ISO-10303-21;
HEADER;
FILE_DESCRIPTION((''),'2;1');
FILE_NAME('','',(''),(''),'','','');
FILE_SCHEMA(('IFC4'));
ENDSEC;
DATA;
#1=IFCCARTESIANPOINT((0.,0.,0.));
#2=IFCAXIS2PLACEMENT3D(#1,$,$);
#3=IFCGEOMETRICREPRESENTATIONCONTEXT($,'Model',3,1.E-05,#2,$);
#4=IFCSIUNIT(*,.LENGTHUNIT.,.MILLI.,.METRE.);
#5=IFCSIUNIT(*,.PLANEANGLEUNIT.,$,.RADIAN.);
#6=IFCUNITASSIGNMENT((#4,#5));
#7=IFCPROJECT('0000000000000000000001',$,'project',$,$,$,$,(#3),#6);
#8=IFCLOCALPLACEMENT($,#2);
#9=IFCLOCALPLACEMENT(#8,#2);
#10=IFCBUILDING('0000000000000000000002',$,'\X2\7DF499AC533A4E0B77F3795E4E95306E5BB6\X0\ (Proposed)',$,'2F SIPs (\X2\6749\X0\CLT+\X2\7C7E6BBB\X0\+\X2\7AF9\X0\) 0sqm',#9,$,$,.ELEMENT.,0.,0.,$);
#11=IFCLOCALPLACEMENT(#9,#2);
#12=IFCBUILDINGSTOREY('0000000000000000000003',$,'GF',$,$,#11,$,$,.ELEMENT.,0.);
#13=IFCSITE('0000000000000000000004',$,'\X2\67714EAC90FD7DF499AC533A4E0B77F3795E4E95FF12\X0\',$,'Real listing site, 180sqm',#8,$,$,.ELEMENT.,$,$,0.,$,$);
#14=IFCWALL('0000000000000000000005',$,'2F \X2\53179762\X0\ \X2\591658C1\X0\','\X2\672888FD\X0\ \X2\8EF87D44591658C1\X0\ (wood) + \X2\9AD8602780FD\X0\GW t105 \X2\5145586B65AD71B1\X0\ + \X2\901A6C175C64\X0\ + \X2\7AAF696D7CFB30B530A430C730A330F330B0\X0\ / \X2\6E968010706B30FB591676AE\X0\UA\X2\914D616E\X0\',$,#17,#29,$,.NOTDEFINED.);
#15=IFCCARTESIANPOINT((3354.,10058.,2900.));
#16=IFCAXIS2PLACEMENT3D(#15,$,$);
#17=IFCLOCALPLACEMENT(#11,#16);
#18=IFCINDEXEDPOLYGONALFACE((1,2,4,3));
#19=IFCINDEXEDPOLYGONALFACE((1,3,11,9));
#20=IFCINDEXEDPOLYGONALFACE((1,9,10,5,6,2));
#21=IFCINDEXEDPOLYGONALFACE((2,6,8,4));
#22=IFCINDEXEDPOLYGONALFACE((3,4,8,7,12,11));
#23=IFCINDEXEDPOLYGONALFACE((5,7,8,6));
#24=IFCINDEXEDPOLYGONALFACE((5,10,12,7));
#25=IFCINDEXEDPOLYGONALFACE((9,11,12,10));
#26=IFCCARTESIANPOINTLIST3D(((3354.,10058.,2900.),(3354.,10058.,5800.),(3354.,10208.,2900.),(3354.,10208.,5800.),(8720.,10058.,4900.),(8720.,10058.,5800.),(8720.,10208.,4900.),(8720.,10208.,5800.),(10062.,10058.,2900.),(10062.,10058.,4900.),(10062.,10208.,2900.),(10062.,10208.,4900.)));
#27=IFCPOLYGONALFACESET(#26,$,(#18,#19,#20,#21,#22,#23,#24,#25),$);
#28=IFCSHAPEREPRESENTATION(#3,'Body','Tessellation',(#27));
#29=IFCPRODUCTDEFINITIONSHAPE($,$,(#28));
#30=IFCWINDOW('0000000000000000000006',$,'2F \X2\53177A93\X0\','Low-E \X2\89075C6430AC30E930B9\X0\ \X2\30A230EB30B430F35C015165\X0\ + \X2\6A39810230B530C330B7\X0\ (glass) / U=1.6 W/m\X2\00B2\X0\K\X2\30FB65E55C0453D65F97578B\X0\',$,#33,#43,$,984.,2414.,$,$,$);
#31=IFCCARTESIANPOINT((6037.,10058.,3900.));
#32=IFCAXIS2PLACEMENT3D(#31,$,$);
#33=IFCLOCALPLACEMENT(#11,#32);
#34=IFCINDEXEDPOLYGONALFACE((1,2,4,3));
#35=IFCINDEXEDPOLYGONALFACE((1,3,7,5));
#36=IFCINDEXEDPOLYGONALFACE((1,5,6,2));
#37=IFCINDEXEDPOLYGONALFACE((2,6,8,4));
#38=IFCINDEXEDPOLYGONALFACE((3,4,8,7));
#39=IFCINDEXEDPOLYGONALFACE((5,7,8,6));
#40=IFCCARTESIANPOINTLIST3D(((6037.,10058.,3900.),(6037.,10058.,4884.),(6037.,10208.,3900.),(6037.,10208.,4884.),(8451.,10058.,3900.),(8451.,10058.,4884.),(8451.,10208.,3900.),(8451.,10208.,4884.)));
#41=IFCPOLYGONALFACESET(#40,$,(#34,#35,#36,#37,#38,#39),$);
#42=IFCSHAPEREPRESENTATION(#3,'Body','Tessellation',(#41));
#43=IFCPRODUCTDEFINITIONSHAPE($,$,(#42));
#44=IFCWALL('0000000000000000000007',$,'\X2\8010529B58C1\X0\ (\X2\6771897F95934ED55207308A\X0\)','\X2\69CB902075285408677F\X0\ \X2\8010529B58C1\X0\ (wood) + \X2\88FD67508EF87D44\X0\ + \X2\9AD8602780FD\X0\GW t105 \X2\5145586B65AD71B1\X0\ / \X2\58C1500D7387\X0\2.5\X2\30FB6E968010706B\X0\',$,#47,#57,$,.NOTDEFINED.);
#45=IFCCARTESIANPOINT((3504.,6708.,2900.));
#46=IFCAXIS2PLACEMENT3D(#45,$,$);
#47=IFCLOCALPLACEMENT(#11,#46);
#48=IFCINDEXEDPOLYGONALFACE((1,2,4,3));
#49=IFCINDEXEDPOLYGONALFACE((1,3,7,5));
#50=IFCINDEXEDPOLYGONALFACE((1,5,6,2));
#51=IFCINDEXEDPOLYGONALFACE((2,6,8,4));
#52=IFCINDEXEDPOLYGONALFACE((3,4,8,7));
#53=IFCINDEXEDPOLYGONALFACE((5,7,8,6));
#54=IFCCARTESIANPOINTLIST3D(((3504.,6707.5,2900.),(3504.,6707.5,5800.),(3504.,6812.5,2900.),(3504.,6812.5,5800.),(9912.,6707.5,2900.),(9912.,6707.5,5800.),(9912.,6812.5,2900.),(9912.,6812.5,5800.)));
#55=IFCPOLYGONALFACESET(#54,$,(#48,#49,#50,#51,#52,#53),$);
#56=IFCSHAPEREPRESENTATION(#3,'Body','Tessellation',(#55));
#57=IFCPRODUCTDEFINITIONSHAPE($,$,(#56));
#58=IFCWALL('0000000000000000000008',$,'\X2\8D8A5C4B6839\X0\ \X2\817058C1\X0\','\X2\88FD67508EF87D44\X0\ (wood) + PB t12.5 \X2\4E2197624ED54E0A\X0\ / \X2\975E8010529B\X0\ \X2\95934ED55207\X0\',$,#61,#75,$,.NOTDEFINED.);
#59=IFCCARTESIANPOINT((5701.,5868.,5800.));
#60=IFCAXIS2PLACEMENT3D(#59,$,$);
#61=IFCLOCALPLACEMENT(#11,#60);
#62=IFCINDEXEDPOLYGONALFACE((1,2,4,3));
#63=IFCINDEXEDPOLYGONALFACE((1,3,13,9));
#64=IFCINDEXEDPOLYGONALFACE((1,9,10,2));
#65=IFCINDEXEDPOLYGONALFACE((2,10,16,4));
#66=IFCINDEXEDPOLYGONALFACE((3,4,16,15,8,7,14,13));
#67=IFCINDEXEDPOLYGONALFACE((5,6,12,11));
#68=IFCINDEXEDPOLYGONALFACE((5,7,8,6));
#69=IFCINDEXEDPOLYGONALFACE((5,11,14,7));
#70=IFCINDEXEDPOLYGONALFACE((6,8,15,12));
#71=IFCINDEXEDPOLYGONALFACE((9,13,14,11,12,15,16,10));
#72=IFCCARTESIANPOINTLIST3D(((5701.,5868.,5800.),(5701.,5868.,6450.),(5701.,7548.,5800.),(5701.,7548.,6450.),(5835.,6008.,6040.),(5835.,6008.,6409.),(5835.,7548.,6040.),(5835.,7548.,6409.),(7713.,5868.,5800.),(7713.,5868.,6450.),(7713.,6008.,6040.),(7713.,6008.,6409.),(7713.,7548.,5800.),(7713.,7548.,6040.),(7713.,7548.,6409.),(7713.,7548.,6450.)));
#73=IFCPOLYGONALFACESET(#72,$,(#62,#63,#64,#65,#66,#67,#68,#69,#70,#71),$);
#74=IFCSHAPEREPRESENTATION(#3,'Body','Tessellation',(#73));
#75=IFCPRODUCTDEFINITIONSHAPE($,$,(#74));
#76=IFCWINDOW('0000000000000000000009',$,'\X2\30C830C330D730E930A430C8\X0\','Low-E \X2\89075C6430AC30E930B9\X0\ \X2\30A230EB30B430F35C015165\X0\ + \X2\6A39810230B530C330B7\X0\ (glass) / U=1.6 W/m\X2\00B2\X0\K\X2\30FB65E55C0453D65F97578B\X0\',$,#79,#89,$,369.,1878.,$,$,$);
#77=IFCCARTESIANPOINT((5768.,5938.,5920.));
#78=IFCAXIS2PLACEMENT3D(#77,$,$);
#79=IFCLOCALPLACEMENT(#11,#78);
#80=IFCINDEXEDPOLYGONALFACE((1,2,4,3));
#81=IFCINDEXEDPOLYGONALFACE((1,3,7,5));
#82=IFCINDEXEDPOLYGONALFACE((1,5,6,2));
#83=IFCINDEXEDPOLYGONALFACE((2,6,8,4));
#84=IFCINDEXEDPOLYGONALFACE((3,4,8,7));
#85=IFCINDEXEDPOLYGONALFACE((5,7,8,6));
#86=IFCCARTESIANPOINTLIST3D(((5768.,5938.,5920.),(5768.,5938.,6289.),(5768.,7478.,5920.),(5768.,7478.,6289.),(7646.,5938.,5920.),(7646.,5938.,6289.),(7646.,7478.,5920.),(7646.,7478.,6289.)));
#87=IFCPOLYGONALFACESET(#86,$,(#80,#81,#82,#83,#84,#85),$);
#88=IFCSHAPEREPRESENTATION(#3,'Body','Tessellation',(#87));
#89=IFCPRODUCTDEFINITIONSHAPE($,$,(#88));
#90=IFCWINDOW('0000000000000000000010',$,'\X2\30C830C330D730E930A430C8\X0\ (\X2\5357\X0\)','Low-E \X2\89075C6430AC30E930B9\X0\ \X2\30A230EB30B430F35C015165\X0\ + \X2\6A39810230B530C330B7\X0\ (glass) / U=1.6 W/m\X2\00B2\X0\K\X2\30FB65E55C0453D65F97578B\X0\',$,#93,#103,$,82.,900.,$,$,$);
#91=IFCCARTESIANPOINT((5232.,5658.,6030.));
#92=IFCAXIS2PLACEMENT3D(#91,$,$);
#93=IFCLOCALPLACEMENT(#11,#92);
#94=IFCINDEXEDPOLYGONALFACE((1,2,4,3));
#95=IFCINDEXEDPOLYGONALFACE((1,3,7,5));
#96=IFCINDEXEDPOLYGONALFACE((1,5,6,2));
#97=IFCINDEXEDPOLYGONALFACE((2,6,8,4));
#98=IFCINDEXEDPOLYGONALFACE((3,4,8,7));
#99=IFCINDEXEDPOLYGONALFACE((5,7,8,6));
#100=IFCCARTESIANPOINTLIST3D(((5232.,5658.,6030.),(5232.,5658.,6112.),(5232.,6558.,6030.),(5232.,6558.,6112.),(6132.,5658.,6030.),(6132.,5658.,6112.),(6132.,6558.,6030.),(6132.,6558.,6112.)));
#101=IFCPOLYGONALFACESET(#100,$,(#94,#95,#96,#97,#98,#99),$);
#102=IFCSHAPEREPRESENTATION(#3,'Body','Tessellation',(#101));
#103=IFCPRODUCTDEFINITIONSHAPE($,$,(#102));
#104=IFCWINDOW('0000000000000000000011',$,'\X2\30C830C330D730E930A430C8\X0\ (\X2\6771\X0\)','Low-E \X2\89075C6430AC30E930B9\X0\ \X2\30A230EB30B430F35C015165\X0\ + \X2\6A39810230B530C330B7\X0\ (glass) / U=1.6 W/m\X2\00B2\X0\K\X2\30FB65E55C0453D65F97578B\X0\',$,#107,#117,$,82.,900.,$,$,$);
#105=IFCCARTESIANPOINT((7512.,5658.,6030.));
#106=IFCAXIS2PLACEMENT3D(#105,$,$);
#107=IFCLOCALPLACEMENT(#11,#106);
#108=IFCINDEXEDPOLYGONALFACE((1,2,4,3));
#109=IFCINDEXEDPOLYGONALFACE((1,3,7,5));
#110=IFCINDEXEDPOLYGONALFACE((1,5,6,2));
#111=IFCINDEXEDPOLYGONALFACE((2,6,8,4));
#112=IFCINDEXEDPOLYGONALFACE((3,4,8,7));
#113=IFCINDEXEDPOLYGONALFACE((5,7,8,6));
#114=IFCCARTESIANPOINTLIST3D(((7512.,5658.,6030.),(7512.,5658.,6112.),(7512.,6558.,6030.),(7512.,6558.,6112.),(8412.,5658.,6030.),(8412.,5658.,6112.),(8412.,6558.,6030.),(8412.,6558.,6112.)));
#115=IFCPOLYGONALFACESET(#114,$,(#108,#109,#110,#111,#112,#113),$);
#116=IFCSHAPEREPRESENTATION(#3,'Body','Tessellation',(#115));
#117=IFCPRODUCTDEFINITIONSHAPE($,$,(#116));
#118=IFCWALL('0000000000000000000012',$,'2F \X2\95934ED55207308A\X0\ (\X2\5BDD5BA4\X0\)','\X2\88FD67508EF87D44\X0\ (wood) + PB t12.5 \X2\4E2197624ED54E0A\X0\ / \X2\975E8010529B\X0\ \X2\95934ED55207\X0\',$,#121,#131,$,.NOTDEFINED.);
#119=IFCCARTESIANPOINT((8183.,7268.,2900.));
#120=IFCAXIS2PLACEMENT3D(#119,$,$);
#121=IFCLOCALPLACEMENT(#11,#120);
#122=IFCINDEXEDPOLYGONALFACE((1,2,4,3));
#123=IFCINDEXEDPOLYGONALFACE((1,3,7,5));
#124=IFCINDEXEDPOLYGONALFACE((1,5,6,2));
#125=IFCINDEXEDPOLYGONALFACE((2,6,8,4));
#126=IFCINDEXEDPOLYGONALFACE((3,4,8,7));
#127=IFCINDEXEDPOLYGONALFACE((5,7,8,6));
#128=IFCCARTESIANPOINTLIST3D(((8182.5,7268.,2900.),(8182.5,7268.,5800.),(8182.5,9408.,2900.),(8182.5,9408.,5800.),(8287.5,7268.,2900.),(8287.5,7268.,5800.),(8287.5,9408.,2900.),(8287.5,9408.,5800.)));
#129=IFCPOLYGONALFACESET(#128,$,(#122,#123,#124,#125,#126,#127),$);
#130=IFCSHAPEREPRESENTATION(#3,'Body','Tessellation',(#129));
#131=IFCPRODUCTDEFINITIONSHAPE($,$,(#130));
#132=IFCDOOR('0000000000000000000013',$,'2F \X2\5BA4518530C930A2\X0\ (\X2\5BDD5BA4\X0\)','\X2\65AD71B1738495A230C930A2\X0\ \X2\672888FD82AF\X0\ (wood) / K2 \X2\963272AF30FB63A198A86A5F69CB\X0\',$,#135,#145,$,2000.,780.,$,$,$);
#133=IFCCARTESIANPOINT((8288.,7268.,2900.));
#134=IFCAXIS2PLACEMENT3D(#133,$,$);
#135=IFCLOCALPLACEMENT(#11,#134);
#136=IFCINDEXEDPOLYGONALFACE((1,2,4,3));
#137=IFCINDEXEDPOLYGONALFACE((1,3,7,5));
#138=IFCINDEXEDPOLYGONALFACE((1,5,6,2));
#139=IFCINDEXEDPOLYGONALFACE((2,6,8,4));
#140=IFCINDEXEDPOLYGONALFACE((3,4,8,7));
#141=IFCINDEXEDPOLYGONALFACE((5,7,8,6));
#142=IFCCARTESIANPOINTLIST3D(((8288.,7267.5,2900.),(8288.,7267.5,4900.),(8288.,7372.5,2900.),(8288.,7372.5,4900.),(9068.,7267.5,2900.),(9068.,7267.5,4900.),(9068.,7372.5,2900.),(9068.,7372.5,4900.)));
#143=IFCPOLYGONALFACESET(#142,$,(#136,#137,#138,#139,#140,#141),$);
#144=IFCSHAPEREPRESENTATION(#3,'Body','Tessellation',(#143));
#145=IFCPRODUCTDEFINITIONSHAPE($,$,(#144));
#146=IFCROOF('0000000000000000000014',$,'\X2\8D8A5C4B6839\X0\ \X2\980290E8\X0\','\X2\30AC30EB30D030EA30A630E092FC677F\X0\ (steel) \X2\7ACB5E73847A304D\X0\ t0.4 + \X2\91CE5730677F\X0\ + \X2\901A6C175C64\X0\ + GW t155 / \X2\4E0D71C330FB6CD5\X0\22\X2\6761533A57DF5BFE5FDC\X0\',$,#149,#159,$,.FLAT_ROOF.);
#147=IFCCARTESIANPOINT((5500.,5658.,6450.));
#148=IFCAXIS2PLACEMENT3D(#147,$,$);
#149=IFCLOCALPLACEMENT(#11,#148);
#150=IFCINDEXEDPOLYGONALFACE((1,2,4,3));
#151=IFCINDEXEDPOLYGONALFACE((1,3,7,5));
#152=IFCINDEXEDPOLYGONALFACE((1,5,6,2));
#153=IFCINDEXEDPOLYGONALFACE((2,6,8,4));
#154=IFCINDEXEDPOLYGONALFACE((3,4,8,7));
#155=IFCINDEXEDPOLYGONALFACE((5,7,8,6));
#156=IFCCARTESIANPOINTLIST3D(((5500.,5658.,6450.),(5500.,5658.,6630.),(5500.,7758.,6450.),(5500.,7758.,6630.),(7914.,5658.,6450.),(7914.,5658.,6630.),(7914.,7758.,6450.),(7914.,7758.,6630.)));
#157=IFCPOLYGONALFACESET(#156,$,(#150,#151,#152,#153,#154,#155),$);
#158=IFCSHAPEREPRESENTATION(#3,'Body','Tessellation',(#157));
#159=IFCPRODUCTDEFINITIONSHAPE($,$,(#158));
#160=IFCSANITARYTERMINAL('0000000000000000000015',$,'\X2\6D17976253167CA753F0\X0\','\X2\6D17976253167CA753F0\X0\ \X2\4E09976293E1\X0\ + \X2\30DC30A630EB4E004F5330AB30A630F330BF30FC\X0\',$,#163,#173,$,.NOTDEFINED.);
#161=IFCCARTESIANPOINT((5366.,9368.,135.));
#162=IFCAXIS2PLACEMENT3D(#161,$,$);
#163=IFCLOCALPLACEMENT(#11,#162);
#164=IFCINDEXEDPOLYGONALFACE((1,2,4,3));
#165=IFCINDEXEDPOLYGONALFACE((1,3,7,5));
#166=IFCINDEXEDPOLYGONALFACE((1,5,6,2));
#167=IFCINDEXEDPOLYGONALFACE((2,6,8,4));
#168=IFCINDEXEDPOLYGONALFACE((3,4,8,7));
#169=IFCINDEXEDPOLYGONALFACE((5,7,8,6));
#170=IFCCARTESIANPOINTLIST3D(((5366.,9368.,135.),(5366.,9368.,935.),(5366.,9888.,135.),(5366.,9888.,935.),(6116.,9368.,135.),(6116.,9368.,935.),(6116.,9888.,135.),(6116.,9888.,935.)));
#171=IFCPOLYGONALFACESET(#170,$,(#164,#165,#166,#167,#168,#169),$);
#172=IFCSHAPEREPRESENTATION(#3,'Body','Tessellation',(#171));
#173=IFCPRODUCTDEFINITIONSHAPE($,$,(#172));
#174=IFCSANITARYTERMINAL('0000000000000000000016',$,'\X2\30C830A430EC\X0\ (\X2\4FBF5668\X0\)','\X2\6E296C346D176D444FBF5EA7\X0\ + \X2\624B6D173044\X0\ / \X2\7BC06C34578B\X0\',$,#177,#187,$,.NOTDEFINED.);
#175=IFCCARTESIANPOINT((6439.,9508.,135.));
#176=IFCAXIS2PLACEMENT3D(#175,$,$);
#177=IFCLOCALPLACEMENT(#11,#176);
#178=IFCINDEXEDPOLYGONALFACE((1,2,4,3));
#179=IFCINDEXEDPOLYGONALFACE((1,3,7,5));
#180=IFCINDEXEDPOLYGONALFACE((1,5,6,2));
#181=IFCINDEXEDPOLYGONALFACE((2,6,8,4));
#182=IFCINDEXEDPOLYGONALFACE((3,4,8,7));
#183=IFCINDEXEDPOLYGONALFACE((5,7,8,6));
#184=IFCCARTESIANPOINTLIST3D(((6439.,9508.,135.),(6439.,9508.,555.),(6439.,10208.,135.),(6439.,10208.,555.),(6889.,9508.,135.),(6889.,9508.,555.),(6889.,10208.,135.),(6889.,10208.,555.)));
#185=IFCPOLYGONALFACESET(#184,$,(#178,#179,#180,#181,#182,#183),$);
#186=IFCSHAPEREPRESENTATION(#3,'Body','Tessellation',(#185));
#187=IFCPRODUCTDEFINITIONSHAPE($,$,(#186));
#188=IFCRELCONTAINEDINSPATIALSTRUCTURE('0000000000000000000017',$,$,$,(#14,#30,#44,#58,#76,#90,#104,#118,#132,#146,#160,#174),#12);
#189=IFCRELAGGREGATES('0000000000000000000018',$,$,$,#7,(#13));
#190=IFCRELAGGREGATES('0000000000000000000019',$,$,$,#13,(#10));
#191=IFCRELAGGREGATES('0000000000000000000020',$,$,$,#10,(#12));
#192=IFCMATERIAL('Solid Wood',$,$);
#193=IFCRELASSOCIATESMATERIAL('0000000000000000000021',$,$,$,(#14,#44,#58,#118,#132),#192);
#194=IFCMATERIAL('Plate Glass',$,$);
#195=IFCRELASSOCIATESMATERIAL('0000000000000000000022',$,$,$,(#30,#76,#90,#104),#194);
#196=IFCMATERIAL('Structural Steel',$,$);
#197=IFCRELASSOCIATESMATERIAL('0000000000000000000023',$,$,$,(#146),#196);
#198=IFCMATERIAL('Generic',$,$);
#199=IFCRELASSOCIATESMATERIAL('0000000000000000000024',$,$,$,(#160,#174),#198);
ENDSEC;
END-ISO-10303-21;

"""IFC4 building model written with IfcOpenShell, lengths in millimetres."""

from ifc_helpers import new_model, si_unit, frame, frame_2d, origin, place, context, project, spatial, rectangle, extrude, material, element, fill, save


model = new_model("IFC4")

# Units and contexts
model_context = context("Model", 3, precision=1e-05, world=origin())
ifc_project = project(units=[si_unit("LENGTHUNIT", "METRE", prefix="MILLI"), si_unit("PLANEANGLEUNIT", "RADIAN")], contexts=[model_context])

# Site, building, storey
site_placement = place(None, origin())
site = spatial("IfcSite", under=ifc_project, at=site_placement, Name="東京都練馬区下石神井２", ObjectType="Real listing site, 180sqm", CompositionType="ELEMENT", RefElevation=0.0)
building_placement = place(site_placement, origin())
building = spatial("IfcBuilding", under=site, at=building_placement, Name="練馬区下石神井の家 (Proposed)", ObjectType="2F SIPs (杉CLT+籾殻+竹) 0sqm", CompositionType="ELEMENT", ElevationOfRefHeight=0.0, ElevationOfTerrain=0.0)
storey_placement = place(building_placement, origin())
storey = spatial("IfcBuildingStorey", under=building, at=storey_placement, Name="GF", CompositionType="ELEMENT", Elevation=0.0)

# Wall, opening, window
ifc_material_1 = material(Name="Solid Wood")
wall_1_placement = place(storey_placement, frame((3354.0, 10058.0, 2900.0)))
wall_1 = element("IfcWall", 1, at=wall_1_placement, inside=storey, material=ifc_material_1, Name="2F 北面 外壁", Description="木製 軸組外壁 (wood) + 高性能GW t105 充填断熱 + 通気層 + 窯業系サイディング / 準耐火・外皮UA配慮", PredefinedType="NOTDEFINED", context=model_context, shape_type="SweptSolid", body=[
    extrude(rectangle(XDim=6708.0, YDim=150.0, at=frame_2d((3354.0, 75.0))), frame((3354.0, 10058.0, 2900.0)), (0.0, 0.0, 1.0), 2900.0),
])
opening_1_placement = place(storey_placement, frame((6037.0, 10058.0, 3900.0)))
opening_1 = element("IfcOpeningElement", 2, at=opening_1_placement, cuts=wall_1, PredefinedType="NOTDEFINED", context=model_context, shape_type="SweptSolid", body=[
    extrude(rectangle(XDim=2414.0, YDim=150.0, at=frame_2d((1207.0, 75.0))), frame((6037.0, 10058.0, 3900.0)), (0.0, 0.0, 1.0), 984.0),
])
ifc_material_2 = material(Name="Plate Glass")
window_1_placement = place(storey_placement, frame((6037.0, 10058.0, 3900.0)))
window_1 = element("IfcWindow", 3, at=window_1_placement, inside=storey, material=ifc_material_2, Name="2F 北窓", Description="Low-E 複層ガラス アルゴン封入 + 樹脂サッシ (glass) / U=1.6 W/m²K・日射取得型", OverallHeight=984.0, OverallWidth=2414.0, context=model_context, shape_type="SweptSolid", body=[
    extrude(rectangle(XDim=2414.0, YDim=150.0, at=frame_2d((1207.0, 75.0))), frame((6037.0, 10058.0, 3900.0)), (0.0, 0.0, 1.0), 984.0),
])
fill(opening_1, window_1)

# Wall
wall_2_placement = place(storey_placement, frame((3504.0, 6708.0, 2900.0)))
element("IfcWall", 4, at=wall_2_placement, inside=storey, material=ifc_material_1, Name="耐力壁 (東西間仕切り)", Description="構造用合板 耐力壁 (wood) + 製材軸組 + 高性能GW t105 充填断熱 / 壁倍率2.5・準耐火", PredefinedType="NOTDEFINED", context=model_context, shape_type="SweptSolid", body=[
    extrude(rectangle(XDim=6408.0, YDim=105.0, at=frame_2d((3204.0, 52.0))), frame((3504.0, 6708.0, 2900.0)), (0.0, 0.0, 1.0), 2900.0),
])

# Wall, openings, windows
wall_3_placement = place(storey_placement, frame((5701.0, 5868.0, 5800.0)))
wall_3 = element("IfcWall", 5, at=wall_3_placement, inside=storey, material=ifc_material_1, Name="越屋根 腰壁", Description="製材軸組 (wood) + PB t12.5 両面仕上 / 非耐力 間仕切", PredefinedType="NOTDEFINED", context=model_context, shape_type="SweptSolid", body=[
    extrude(rectangle(XDim=2012.0, YDim=1680.0, at=frame_2d((1006.0, 840.0))), frame((5701.0, 5868.0, 5800.0)), (0.0, 0.0, 1.0), 650.0),
])
opening_2_placement = place(storey_placement, frame((5768.0, 5938.0, 5920.0)))
opening_2 = element("IfcOpeningElement", 6, at=opening_2_placement, cuts=wall_3, PredefinedType="NOTDEFINED", context=model_context, shape_type="SweptSolid", body=[
    extrude(rectangle(XDim=1878.0, YDim=1540.0, at=frame_2d((939.0, 770.0))), frame((5768.0, 5938.0, 5920.0)), (0.0, 0.0, 1.0), 369.0),
])
opening_3_placement = place(storey_placement, frame((5232.0, 5658.0, 6030.0)))
opening_3 = element("IfcOpeningElement", 7, at=opening_3_placement, cuts=wall_3, PredefinedType="NOTDEFINED", context=model_context, shape_type="SweptSolid", body=[
    extrude(rectangle(XDim=900.0, YDim=900.0, at=frame_2d((450.0, 450.0))), frame((5232.0, 5658.0, 6030.0)), (0.0, 0.0, 1.0), 82.0),
])
opening_4_placement = place(storey_placement, frame((7512.0, 5658.0, 6030.0)))
opening_4 = element("IfcOpeningElement", 8, at=opening_4_placement, cuts=wall_3, PredefinedType="NOTDEFINED", context=model_context, shape_type="SweptSolid", body=[
    extrude(rectangle(XDim=900.0, YDim=900.0, at=frame_2d((450.0, 450.0))), frame((7512.0, 5658.0, 6030.0)), (0.0, 0.0, 1.0), 82.0),
])
window_2_placement = place(storey_placement, frame((5768.0, 5938.0, 5920.0)))
window_2 = element("IfcWindow", 9, at=window_2_placement, inside=storey, material=ifc_material_2, Name="トップライト", Description="Low-E 複層ガラス アルゴン封入 + 樹脂サッシ (glass) / U=1.6 W/m²K・日射取得型", OverallHeight=369.0, OverallWidth=1878.0, context=model_context, shape_type="SweptSolid", body=[
    extrude(rectangle(XDim=1878.0, YDim=1540.0, at=frame_2d((939.0, 770.0))), frame((5768.0, 5938.0, 5920.0)), (0.0, 0.0, 1.0), 369.0),
])
fill(opening_2, window_2)
window_3_placement = place(storey_placement, frame((5232.0, 5658.0, 6030.0)))
window_3 = element("IfcWindow", 10, at=window_3_placement, inside=storey, material=ifc_material_2, Name="トップライト (南)", Description="Low-E 複層ガラス アルゴン封入 + 樹脂サッシ (glass) / U=1.6 W/m²K・日射取得型", OverallHeight=82.0, OverallWidth=900.0, context=model_context, shape_type="SweptSolid", body=[
    extrude(rectangle(XDim=900.0, YDim=900.0, at=frame_2d((450.0, 450.0))), frame((5232.0, 5658.0, 6030.0)), (0.0, 0.0, 1.0), 82.0),
])
fill(opening_3, window_3)
window_4_placement = place(storey_placement, frame((7512.0, 5658.0, 6030.0)))
window_4 = element("IfcWindow", 11, at=window_4_placement, inside=storey, material=ifc_material_2, Name="トップライト (東)", Description="Low-E 複層ガラス アルゴン封入 + 樹脂サッシ (glass) / U=1.6 W/m²K・日射取得型", OverallHeight=82.0, OverallWidth=900.0, context=model_context, shape_type="SweptSolid", body=[
    extrude(rectangle(XDim=900.0, YDim=900.0, at=frame_2d((450.0, 450.0))), frame((7512.0, 5658.0, 6030.0)), (0.0, 0.0, 1.0), 82.0),
])
fill(opening_4, window_4)

# Wall
wall_4_placement = place(storey_placement, frame((8183.0, 7268.0, 2900.0)))
element("IfcWall", 12, at=wall_4_placement, inside=storey, material=ifc_material_1, Name="2F 間仕切り (寝室)", Description="製材軸組 (wood) + PB t12.5 両面仕上 / 非耐力 間仕切", PredefinedType="NOTDEFINED", context=model_context, shape_type="SweptSolid", body=[
    extrude(rectangle(XDim=105.0, YDim=2140.0, at=frame_2d((52.0, 1070.0))), frame((8183.0, 7268.0, 2900.0)), (0.0, 0.0, 1.0), 2900.0),
])

# Door
door_placement = place(storey_placement, frame((8288.0, 7268.0, 2900.0)))
element("IfcDoor", 13, at=door_placement, inside=storey, material=ifc_material_1, Name="2F 室内ドア (寝室)", Description="断熱玄関ドア 木製芯 (wood) / K2 防犯・採風機構", OverallHeight=2000.0, OverallWidth=780.0, context=model_context, shape_type="SweptSolid", body=[
    extrude(rectangle(XDim=780.0, YDim=105.0, at=frame_2d((390.0, 52.0))), frame((8288.0, 7268.0, 2900.0)), (0.0, 0.0, 1.0), 2000.0),
])

# Roof
ifc_material_3 = material(Name="Structural Steel")
roof_placement = place(storey_placement, frame((5500.0, 5658.0, 6450.0)))
element("IfcRoof", 14, at=roof_placement, inside=storey, material=ifc_material_3, Name="越屋根 頂部", Description="ガルバリウム鋼板 (steel) 立平葺き t0.4 + 野地板 + 通気層 + GW t155 / 不燃・法22条区域対応", PredefinedType="FLAT_ROOF", context=model_context, shape_type="SweptSolid", body=[
    extrude(rectangle(XDim=2414.0, YDim=2100.0, at=frame_2d((1207.0, 1050.0))), frame((5500.0, 5658.0, 6450.0)), (0.0, 0.0, 1.0), 180.0),
])

# Sanitary terminals
ifc_material_4 = material(Name="Generic")
sanitary_terminal_1_placement = place(storey_placement, frame((5366.0, 9368.0, 135.0)))
element("IfcSanitaryTerminal", 15, at=sanitary_terminal_1_placement, inside=storey, material=ifc_material_4, Name="洗面化粧台", Description="洗面化粧台 三面鏡 + ボウル一体カウンター", PredefinedType="NOTDEFINED", context=model_context, shape_type="SweptSolid", body=[
    extrude(rectangle(XDim=750.0, YDim=520.0, at=frame_2d((375.0, 260.0))), frame((5366.0, 9368.0, 135.0)), (0.0, 0.0, 1.0), 800.0),
])
sanitary_terminal_2_placement = place(storey_placement, frame((6439.0, 9508.0, 135.0)))
element("IfcSanitaryTerminal", 16, at=sanitary_terminal_2_placement, inside=storey, material=ifc_material_4, Name="トイレ (便器)", Description="温水洗浄便座 + 手洗い / 節水型", PredefinedType="NOTDEFINED", context=model_context, shape_type="SweptSolid", body=[
    extrude(rectangle(XDim=450.0, YDim=700.0, at=frame_2d((225.0, 350.0))), frame((6439.0, 9508.0, 135.0)), (0.0, 0.0, 1.0), 420.0),
])

save(model, "model.ifc")
